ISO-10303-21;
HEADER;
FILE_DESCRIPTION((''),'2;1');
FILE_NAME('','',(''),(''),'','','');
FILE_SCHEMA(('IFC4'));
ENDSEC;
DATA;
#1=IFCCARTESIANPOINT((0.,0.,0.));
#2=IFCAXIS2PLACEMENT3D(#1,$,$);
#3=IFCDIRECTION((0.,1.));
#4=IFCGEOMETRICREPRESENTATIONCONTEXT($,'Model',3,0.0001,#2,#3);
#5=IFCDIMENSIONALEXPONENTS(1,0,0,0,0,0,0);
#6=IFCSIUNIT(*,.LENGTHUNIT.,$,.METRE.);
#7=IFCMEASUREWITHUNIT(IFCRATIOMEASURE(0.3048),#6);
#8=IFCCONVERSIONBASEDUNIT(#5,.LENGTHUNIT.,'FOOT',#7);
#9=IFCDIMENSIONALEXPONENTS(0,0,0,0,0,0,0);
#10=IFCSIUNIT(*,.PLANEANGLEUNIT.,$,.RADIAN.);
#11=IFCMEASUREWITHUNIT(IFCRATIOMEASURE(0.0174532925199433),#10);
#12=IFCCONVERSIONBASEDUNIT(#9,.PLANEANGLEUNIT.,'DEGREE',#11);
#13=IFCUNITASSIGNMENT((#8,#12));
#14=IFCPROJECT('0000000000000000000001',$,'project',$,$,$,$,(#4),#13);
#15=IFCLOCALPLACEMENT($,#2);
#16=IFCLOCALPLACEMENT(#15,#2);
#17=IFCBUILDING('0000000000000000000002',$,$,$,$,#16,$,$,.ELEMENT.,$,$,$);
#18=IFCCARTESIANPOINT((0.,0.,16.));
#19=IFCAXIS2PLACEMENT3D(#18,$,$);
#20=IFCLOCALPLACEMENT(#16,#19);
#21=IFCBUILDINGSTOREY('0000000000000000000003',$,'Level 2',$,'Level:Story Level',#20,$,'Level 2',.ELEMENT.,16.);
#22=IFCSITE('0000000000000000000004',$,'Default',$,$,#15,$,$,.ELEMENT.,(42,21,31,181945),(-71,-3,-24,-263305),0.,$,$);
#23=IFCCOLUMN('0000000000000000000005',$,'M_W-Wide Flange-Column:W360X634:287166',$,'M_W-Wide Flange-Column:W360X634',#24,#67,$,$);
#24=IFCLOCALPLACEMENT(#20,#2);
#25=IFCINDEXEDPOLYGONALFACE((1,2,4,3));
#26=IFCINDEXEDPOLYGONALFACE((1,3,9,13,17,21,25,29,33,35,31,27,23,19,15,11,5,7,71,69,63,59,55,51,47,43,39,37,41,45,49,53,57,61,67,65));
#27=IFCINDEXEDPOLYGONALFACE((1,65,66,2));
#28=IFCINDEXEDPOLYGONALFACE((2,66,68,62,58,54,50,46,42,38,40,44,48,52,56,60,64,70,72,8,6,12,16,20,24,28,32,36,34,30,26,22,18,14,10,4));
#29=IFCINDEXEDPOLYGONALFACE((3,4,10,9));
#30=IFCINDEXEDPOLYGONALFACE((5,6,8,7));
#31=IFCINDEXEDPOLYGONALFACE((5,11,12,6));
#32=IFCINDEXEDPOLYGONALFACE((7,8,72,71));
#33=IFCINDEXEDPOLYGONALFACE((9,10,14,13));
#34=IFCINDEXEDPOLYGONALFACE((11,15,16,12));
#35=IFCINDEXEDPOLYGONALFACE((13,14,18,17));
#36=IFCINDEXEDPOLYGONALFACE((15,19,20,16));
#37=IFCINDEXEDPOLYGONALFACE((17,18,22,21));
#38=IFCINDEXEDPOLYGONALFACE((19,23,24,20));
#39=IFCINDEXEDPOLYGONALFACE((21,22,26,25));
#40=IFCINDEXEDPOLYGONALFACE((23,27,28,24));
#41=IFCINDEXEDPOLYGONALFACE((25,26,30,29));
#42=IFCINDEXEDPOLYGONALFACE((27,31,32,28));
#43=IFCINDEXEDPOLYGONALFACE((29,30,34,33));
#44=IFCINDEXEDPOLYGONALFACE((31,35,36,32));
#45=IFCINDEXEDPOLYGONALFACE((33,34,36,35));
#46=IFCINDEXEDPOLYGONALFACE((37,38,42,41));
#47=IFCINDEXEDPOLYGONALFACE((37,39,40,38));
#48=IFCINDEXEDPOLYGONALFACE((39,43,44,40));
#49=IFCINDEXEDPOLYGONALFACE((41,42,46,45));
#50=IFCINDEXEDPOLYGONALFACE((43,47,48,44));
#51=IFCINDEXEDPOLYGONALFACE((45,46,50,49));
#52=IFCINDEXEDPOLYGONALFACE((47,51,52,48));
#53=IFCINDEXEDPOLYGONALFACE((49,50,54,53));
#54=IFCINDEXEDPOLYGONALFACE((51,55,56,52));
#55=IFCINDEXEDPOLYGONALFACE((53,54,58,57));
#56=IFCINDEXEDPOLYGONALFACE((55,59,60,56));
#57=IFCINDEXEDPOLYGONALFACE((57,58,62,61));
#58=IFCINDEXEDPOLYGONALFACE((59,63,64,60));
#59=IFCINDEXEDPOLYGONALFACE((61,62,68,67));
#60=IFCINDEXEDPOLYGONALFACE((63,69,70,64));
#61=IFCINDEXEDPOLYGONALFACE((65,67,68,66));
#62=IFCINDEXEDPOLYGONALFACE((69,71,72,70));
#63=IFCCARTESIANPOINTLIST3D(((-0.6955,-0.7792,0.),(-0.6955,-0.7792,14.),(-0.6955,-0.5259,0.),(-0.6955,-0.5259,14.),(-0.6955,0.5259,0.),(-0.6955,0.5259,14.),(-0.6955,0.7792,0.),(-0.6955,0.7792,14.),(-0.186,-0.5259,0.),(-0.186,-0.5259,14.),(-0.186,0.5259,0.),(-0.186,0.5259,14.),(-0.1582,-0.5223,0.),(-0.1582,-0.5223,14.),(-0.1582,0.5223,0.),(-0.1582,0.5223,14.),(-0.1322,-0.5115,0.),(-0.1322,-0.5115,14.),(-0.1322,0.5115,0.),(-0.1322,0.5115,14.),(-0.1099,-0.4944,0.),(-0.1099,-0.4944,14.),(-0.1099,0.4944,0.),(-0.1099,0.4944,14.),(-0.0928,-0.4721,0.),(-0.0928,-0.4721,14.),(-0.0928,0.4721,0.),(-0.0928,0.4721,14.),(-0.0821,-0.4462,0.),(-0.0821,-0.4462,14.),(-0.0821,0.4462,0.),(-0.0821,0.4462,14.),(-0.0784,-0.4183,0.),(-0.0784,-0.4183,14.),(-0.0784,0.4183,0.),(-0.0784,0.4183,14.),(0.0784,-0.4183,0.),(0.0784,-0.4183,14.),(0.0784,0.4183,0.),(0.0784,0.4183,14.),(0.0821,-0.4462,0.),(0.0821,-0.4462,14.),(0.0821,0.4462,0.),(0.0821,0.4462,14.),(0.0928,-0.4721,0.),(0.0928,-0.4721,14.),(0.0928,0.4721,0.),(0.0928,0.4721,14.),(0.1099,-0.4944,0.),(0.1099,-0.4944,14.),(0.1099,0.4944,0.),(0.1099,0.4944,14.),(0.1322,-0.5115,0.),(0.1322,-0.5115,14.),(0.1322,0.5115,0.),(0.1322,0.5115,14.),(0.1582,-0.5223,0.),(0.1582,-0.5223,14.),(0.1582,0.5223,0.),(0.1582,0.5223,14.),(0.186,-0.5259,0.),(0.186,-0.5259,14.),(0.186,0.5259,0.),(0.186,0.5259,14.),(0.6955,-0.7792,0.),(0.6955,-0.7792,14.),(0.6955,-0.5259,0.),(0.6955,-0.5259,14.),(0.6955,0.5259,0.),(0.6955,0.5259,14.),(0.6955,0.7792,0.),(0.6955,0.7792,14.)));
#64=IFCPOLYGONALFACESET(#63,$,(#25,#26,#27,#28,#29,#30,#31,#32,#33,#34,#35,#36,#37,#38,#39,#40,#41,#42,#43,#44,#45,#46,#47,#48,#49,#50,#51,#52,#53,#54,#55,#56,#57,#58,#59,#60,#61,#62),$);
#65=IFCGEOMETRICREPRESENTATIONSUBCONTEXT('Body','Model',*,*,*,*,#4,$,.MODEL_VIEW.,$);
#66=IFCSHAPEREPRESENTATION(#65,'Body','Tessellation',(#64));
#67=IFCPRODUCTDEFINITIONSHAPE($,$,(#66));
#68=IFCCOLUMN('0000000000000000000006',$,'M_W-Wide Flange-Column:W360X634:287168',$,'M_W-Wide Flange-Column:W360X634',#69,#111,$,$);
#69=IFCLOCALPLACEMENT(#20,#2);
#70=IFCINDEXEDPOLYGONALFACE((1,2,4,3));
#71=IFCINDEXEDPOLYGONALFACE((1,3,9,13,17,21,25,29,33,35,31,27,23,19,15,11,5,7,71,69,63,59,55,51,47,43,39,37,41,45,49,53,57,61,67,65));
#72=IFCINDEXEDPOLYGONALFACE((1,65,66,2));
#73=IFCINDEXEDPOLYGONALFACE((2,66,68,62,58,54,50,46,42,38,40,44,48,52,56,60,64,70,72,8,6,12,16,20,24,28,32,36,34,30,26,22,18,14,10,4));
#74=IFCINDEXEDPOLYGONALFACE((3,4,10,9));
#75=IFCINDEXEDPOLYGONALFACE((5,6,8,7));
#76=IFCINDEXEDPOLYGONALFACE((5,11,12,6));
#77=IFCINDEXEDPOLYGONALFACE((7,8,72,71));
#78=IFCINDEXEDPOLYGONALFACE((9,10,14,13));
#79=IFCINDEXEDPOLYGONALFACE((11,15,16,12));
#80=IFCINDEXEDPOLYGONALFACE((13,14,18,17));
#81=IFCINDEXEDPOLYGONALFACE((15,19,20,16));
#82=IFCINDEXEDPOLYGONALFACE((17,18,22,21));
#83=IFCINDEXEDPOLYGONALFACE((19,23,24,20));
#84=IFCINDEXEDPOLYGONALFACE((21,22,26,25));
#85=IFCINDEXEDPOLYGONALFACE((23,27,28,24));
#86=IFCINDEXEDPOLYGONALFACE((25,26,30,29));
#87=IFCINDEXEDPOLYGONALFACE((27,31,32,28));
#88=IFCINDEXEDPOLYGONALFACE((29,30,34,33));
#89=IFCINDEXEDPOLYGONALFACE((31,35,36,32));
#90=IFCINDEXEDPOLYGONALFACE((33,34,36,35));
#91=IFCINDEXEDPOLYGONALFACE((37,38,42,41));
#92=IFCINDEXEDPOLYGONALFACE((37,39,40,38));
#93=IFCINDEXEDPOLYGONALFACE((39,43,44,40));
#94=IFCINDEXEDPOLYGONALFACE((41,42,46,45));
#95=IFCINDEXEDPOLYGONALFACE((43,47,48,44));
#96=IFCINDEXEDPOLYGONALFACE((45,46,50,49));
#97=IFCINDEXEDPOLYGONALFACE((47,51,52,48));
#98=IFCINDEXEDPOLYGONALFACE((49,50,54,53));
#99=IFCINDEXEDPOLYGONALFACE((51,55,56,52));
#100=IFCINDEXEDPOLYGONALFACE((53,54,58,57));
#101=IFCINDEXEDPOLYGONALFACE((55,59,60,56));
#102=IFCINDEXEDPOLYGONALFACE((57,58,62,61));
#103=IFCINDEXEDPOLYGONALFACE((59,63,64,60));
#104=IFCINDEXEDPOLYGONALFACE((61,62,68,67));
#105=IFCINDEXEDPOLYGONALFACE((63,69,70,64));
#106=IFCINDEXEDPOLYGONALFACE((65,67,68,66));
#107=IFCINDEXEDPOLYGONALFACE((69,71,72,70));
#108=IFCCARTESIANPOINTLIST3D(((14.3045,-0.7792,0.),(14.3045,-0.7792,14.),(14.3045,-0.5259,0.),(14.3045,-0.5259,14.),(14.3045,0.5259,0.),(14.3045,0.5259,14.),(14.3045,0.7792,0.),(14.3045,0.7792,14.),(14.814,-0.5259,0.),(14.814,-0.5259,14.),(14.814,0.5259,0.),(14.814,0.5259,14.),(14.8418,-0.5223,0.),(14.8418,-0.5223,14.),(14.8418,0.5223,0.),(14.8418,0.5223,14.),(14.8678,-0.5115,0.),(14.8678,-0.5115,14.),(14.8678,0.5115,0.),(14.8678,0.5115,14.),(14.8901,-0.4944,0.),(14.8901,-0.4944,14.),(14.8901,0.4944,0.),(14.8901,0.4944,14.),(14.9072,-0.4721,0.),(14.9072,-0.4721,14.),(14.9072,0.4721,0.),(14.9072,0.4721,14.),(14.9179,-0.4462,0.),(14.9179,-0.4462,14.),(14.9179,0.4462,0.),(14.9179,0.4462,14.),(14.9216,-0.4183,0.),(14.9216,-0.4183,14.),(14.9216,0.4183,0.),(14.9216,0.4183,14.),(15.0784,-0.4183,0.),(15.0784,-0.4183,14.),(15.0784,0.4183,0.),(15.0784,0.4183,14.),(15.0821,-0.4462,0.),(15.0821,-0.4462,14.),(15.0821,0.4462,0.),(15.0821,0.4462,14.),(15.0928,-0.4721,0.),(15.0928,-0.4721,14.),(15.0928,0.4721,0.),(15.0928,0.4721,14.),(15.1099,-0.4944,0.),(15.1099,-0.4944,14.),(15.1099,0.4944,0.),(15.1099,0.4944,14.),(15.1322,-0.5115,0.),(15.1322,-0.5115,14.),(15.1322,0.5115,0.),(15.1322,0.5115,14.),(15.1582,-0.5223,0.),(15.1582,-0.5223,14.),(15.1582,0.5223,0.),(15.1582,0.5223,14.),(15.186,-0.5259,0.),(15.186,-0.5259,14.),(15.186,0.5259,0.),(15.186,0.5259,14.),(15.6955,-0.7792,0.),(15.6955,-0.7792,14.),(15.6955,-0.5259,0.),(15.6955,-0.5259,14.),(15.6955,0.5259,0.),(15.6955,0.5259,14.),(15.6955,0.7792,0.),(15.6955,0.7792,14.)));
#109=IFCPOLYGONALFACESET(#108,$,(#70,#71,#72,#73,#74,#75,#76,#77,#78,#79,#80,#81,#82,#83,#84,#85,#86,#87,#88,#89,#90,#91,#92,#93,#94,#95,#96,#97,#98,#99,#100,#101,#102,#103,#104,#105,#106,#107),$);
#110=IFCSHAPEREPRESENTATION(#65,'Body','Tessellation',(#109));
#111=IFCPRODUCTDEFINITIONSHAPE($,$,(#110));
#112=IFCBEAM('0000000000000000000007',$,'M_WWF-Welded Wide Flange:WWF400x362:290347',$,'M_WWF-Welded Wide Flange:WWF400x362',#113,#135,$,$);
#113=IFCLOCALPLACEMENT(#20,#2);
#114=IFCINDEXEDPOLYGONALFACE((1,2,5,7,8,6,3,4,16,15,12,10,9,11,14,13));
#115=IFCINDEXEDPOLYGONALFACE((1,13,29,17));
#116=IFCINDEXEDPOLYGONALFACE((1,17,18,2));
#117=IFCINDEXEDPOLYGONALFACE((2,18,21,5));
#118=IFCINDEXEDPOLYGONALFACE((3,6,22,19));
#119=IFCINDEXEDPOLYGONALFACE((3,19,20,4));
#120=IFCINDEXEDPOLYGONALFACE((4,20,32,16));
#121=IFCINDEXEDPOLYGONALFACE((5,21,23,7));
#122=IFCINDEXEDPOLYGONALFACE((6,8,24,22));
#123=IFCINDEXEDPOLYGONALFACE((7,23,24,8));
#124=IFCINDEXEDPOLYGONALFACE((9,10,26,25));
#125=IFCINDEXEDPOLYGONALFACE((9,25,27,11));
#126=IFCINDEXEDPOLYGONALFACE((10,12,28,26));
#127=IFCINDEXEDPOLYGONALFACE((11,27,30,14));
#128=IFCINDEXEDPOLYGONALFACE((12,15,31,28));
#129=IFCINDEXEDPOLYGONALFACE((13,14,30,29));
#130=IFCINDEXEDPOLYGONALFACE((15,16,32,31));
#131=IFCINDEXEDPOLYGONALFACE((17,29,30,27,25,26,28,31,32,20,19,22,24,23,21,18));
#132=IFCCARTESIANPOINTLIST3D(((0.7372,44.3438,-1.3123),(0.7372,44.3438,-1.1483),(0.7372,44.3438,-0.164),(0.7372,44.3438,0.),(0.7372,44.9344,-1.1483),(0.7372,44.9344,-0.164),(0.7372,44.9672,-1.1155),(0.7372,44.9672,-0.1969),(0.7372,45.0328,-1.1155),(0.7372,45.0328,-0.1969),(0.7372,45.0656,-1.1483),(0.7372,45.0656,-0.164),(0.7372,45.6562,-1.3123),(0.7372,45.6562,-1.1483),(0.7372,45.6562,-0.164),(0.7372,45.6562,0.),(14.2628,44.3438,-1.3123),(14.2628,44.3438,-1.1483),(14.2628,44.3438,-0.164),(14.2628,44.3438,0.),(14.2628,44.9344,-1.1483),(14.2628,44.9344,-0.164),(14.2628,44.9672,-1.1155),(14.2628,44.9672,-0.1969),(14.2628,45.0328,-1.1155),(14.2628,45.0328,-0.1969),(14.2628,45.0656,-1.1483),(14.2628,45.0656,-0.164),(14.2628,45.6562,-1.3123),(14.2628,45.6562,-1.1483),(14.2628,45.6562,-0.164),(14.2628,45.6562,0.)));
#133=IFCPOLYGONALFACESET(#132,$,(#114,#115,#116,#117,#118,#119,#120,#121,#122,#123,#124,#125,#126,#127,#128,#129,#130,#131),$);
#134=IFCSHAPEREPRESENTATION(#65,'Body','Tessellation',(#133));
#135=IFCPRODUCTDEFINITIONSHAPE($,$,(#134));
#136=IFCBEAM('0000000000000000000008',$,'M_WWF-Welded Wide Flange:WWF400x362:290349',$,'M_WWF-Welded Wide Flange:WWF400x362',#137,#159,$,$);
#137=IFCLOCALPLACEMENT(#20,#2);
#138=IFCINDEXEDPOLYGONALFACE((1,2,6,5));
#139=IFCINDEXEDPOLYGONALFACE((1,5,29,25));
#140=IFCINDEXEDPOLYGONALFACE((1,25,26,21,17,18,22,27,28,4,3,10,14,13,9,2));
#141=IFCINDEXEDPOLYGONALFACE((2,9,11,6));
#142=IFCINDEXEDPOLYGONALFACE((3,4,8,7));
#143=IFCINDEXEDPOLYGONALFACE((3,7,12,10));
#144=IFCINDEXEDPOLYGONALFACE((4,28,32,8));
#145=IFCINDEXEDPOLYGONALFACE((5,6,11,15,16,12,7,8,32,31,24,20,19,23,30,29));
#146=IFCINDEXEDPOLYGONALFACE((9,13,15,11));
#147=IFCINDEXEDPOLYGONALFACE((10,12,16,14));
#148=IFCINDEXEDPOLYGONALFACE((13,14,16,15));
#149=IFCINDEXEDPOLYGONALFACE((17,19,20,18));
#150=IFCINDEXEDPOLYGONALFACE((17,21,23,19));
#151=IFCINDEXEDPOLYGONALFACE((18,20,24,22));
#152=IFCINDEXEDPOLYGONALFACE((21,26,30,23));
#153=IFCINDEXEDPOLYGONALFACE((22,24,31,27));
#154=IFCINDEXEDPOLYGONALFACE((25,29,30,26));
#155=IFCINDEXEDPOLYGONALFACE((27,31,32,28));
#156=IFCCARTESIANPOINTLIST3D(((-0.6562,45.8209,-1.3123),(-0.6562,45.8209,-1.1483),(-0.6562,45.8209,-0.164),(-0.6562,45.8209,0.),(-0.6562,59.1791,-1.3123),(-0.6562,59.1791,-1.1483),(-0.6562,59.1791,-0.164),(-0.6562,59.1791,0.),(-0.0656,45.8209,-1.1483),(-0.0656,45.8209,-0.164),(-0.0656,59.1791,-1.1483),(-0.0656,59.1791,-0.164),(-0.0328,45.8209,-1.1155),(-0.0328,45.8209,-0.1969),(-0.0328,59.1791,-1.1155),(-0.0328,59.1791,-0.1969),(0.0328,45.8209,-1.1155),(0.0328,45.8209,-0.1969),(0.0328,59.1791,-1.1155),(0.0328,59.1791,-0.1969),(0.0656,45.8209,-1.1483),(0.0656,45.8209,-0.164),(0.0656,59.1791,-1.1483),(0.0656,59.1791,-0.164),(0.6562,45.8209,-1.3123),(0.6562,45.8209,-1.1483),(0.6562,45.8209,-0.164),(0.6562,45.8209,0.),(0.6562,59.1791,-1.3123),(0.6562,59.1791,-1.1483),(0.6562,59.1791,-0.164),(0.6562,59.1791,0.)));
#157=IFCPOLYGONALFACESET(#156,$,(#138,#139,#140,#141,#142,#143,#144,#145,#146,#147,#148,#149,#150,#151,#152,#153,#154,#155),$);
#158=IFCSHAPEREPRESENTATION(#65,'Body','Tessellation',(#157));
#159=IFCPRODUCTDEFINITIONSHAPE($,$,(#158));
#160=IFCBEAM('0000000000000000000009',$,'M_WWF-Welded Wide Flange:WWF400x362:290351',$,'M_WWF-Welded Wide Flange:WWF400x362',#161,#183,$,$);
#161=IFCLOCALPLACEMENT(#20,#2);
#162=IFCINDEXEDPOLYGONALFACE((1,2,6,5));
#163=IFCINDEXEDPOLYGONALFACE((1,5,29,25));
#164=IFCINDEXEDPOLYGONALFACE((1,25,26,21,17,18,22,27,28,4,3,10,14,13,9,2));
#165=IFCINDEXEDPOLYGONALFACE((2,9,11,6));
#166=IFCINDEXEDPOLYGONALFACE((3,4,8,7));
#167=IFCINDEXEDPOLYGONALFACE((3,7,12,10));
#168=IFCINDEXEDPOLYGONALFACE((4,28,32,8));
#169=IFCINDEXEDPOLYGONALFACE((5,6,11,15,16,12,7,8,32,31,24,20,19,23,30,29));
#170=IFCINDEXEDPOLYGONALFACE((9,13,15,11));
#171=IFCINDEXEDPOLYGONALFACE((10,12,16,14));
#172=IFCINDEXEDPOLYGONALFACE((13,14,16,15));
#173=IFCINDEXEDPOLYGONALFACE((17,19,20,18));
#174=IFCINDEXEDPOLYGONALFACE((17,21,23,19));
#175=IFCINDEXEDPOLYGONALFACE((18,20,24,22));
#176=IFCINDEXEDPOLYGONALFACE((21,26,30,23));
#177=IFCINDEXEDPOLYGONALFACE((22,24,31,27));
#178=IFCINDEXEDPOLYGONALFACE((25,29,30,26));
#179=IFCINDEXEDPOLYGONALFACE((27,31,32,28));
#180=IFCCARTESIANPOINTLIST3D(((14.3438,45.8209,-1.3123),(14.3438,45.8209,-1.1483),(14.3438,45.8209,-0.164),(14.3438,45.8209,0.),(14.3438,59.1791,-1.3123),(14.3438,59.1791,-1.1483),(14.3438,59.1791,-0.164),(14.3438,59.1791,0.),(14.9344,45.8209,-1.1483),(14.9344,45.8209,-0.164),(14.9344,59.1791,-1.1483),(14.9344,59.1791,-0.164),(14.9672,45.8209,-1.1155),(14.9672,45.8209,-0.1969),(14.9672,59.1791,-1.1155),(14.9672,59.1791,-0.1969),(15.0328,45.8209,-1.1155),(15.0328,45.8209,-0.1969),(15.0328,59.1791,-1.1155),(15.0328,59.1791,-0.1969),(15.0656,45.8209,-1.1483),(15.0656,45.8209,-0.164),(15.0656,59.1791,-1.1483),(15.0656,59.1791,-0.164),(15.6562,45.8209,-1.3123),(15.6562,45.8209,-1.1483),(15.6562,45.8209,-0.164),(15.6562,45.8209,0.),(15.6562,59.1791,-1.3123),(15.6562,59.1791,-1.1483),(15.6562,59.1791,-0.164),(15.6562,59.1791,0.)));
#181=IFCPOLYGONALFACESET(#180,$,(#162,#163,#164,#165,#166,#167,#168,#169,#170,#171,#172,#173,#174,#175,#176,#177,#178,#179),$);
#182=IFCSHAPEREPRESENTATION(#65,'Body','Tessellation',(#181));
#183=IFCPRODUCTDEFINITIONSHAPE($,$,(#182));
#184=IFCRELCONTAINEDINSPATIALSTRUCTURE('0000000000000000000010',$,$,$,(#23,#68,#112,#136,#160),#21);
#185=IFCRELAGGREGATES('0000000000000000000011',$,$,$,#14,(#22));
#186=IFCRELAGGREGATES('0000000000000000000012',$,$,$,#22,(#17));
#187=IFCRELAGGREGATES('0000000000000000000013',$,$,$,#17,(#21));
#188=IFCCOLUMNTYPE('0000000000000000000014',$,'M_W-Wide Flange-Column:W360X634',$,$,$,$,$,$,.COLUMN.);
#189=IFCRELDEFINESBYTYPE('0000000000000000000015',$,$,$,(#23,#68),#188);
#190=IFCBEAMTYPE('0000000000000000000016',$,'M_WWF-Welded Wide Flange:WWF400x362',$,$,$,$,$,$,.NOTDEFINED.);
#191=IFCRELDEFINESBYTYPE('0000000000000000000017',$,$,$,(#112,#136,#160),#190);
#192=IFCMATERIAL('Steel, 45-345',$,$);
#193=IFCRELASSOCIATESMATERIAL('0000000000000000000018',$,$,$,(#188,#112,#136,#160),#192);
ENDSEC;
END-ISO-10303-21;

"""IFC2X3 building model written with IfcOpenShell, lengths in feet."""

from ifc_helpers import new_model, entity, si_unit, converted_unit, direction, frame, frame_2d, origin, place, context, subcontext, project, spatial, polyline, circle_curve, parameter, trimmed, segment, composite_curve, outline, extrude, source, transform, mapped, material, type_object, type_shapes, element, save


model = new_model("IFC2X3")

# Units and contexts
model_context = context("Model", 3, precision=0.0001, world=origin(), true_north=direction((0.0, 1.0)))
body_context = subcontext(model_context, "Body", "Model", "MODEL_VIEW")
ifc_project = project(units=[converted_unit("LENGTHUNIT", "FOOT", entity("IfcRatioMeasure", 0.3048), si_unit("LENGTHUNIT", "METRE"), dimensions=[1, 0, 0, 0, 0, 0, 0]), converted_unit("PLANEANGLEUNIT", "DEGREE", entity("IfcRatioMeasure", 0.0174532925199433), si_unit("PLANEANGLEUNIT", "RADIAN"), dimensions=[0, 0, 0, 0, 0, 0, 0])], contexts=[model_context])

# Site, building, storey
site_placement = place(None, origin())
site = spatial("IfcSite", under=ifc_project, at=site_placement, Name="Default", CompositionType="ELEMENT", RefLatitude=(42, 21, 31, 181945), RefLongitude=(-71, -3, -24, -263305), RefElevation=0.0)
building_placement = place(site_placement, origin())
building = spatial("IfcBuilding", under=site, at=building_placement, CompositionType="ELEMENT")
storey_placement = place(building_placement, frame((0.0, 0.0, 16.0)))
storey = spatial("IfcBuildingStorey", under=building, at=storey_placement, Name="Level 2", ObjectType="Level:Story Level", LongName="Level 2", CompositionType="ELEMENT", Elevation=16.0)

# Columns
ifc_material = material(Name="Steel, 45-345")
column_type = type_object("IfcColumnType", Name="M_W-Wide Flange-Column:W360X634", PredefinedType="COLUMN", material=ifc_material)
shared_shape = source(origin(), body_context, "Body", "SweptSolid", [
    extrude(outline(composite_curve([segment(polyline([(0.5259, -0.6955), (0.7792, -0.6955)]), True, "CONTINUOUS"), segment(polyline([(0.7792, -0.6955), (0.7792, 0.6955)]), True, "CONTINUOUS"), segment(polyline([(0.7792, 0.6955), (0.5259, 0.6955)]), True, "CONTINUOUS"), segment(polyline([(0.5259, 0.6955), (0.5259, 0.186)]), True, "CONTINUOUS"), segment(trimmed(circle_curve(frame_2d((0.4183, 0.186), x_axis=(1.0, 0.0)), 0.1076), [parameter(270.0)], [parameter(0.0)], True, "PARAMETER"), False, "CONTINUOUS"), segment(polyline([(0.4183, 0.0784), (-0.4183, 0.0784)]), True, "CONTINUOUS"), segment(trimmed(circle_curve(frame_2d((-0.4183, 0.186), x_axis=(0.0, -1.0)), 0.1076), [parameter(270.0)], [parameter(0.0)], True, "PARAMETER"), False, "CONTINUOUS"), segment(polyline([(-0.5259, 0.186), (-0.5259, 0.6955)]), True, "CONTINUOUS"), segment(polyline([(-0.5259, 0.6955), (-0.7792, 0.6955)]), True, "CONTINUOUS"), segment(polyline([(-0.7792, 0.6955), (-0.7792, -0.6955)]), True, "CONTINUOUS"), segment(polyline([(-0.7792, -0.6955), (-0.5259, -0.6955)]), True, "CONTINUOUS"), segment(polyline([(-0.5259, -0.6955), (-0.5259, -0.186)]), True, "CONTINUOUS"), segment(trimmed(circle_curve(frame_2d((-0.4183, -0.186), x_axis=(-1.0, 0.0)), 0.1076), [parameter(270.0)], [parameter(0.0)], True, "PARAMETER"), False, "CONTINUOUS"), segment(polyline([(-0.4183, -0.0784), (0.4183, -0.0784)]), True, "CONTINUOUS"), segment(trimmed(circle_curve(frame_2d((0.4183, -0.186), x_axis=(0.0, 1.0)), 0.1076), [parameter(270.0)], [parameter(0.0)], True, "PARAMETER"), False, "CONTINUOUS"), segment(polyline([(0.5259, -0.186), (0.5259, -0.6955)]), True, "CONTINUOUS")], self_intersect=False)), frame((0.0, 0.0, 16.0), z_axis=(0.0, 0.0, 1.0), x_axis=(0.0, -1.0, 0.0)), (0.0, 0.0, 1.0), 14.0),
])
type_shapes(column_type, [shared_shape])
for number, where, name in (
    (1, (0.0, 0.0, -16.0), "M_W-Wide Flange-Column:W360X634:287166"),
    (2, (15.0, 0.0, -16.0), "M_W-Wide Flange-Column:W360X634:287168"),
):
    element("IfcColumn", number, at=place(storey_placement, frame(where)), inside=storey, type_object=column_type, Name=name, ObjectType="M_W-Wide Flange-Column:W360X634", context=body_context, shape_type="MappedRepresentation", body=[
        mapped(shared_shape, transform((0.0, 0.0, 0.0), scale=1.0)),
    ])

# Beams
beam_type = type_object("IfcBeamType", Name="M_WWF-Welded Wide Flange:WWF400x362", PredefinedType="NOTDEFINED")
beam_1_placement = place(storey_placement, frame((0.0, 45.0, 0.0)))
element("IfcBeam", 3, at=beam_1_placement, inside=storey, type_object=beam_type, material=ifc_material, Name="M_WWF-Welded Wide Flange:WWF400x362:290347", ObjectType="M_WWF-Welded Wide Flange:WWF400x362", context=body_context, shape_type="SweptSolid", body=[
    extrude(outline(polyline([(-0.6562, -0.6562), (-0.4921, -0.6562), (-0.4921, -0.0656), (-0.4593, -0.0328), (0.4593, -0.0328), (0.4921, -0.0656), (0.4921, -0.6562), (0.6562, -0.6562), (0.6562, 0.6562), (0.4921, 0.6562), (0.4921, 0.0656), (0.4593, 0.0328), (-0.4593, 0.0328), (-0.4921, 0.0656), (-0.4921, 0.6562), (-0.6562, 0.6562), (-0.6562, -0.6562)])), frame((0.7372, 0.0, -0.6562), z_axis=(1.0, 0.0, 0.0), x_axis=(0.0, 0.0, -1.0)), (0.0, 0.0, 1.0), 13.5256),
])
beam_2_placement = place(storey_placement, frame((0.0, 45.0, 0.0), z_axis=(0.0, 0.0, 1.0), x_axis=(0.0, 1.0, 0.0)))
element("IfcBeam", 4, at=beam_2_placement, inside=storey, type_object=beam_type, material=ifc_material, Name="M_WWF-Welded Wide Flange:WWF400x362:290349", ObjectType="M_WWF-Welded Wide Flange:WWF400x362", context=body_context, shape_type="SweptSolid", body=[
    extrude(outline(polyline([(-0.6562, -0.6562), (-0.4921, -0.6562), (-0.4921, -0.0656), (-0.4593, -0.0328), (0.4593, -0.0328), (0.4921, -0.0656), (0.4921, -0.6562), (0.6562, -0.6562), (0.6562, 0.6562), (0.4921, 0.6562), (0.4921, 0.0656), (0.4593, 0.0328), (-0.4593, 0.0328), (-0.4921, 0.0656), (-0.4921, 0.6562), (-0.6562, 0.6562), (-0.6562, -0.6562)])), frame((0.8209, 0.0, -0.6562), z_axis=(1.0, 0.0, 0.0), x_axis=(0.0, 0.0, -1.0)), (0.0, 0.0, 1.0), 13.3583),
])
beam_3_placement = place(storey_placement, frame((15.0, 45.0, 0.0), z_axis=(0.0, 0.0, 1.0), x_axis=(0.0, 1.0, 0.0)))
element("IfcBeam", 5, at=beam_3_placement, inside=storey, type_object=beam_type, material=ifc_material, Name="M_WWF-Welded Wide Flange:WWF400x362:290351", ObjectType="M_WWF-Welded Wide Flange:WWF400x362", context=body_context, shape_type="SweptSolid", body=[
    extrude(outline(polyline([(-0.6562, -0.6562), (-0.4921, -0.6562), (-0.4921, -0.0656), (-0.4593, -0.0328), (0.4593, -0.0328), (0.4921, -0.0656), (0.4921, -0.6562), (0.6562, -0.6562), (0.6562, 0.6562), (0.4921, 0.6562), (0.4921, 0.0656), (0.4593, 0.0328), (-0.4593, 0.0328), (-0.4921, 0.0656), (-0.4921, 0.6562), (-0.6562, 0.6562), (-0.6562, -0.6562)])), frame((0.8209, 0.0, -0.6562), z_axis=(1.0, 0.0, 0.0), x_axis=(0.0, 0.0, -1.0)), (0.0, 0.0, 1.0), 13.3583),
])

save(model, "model.ifc")
